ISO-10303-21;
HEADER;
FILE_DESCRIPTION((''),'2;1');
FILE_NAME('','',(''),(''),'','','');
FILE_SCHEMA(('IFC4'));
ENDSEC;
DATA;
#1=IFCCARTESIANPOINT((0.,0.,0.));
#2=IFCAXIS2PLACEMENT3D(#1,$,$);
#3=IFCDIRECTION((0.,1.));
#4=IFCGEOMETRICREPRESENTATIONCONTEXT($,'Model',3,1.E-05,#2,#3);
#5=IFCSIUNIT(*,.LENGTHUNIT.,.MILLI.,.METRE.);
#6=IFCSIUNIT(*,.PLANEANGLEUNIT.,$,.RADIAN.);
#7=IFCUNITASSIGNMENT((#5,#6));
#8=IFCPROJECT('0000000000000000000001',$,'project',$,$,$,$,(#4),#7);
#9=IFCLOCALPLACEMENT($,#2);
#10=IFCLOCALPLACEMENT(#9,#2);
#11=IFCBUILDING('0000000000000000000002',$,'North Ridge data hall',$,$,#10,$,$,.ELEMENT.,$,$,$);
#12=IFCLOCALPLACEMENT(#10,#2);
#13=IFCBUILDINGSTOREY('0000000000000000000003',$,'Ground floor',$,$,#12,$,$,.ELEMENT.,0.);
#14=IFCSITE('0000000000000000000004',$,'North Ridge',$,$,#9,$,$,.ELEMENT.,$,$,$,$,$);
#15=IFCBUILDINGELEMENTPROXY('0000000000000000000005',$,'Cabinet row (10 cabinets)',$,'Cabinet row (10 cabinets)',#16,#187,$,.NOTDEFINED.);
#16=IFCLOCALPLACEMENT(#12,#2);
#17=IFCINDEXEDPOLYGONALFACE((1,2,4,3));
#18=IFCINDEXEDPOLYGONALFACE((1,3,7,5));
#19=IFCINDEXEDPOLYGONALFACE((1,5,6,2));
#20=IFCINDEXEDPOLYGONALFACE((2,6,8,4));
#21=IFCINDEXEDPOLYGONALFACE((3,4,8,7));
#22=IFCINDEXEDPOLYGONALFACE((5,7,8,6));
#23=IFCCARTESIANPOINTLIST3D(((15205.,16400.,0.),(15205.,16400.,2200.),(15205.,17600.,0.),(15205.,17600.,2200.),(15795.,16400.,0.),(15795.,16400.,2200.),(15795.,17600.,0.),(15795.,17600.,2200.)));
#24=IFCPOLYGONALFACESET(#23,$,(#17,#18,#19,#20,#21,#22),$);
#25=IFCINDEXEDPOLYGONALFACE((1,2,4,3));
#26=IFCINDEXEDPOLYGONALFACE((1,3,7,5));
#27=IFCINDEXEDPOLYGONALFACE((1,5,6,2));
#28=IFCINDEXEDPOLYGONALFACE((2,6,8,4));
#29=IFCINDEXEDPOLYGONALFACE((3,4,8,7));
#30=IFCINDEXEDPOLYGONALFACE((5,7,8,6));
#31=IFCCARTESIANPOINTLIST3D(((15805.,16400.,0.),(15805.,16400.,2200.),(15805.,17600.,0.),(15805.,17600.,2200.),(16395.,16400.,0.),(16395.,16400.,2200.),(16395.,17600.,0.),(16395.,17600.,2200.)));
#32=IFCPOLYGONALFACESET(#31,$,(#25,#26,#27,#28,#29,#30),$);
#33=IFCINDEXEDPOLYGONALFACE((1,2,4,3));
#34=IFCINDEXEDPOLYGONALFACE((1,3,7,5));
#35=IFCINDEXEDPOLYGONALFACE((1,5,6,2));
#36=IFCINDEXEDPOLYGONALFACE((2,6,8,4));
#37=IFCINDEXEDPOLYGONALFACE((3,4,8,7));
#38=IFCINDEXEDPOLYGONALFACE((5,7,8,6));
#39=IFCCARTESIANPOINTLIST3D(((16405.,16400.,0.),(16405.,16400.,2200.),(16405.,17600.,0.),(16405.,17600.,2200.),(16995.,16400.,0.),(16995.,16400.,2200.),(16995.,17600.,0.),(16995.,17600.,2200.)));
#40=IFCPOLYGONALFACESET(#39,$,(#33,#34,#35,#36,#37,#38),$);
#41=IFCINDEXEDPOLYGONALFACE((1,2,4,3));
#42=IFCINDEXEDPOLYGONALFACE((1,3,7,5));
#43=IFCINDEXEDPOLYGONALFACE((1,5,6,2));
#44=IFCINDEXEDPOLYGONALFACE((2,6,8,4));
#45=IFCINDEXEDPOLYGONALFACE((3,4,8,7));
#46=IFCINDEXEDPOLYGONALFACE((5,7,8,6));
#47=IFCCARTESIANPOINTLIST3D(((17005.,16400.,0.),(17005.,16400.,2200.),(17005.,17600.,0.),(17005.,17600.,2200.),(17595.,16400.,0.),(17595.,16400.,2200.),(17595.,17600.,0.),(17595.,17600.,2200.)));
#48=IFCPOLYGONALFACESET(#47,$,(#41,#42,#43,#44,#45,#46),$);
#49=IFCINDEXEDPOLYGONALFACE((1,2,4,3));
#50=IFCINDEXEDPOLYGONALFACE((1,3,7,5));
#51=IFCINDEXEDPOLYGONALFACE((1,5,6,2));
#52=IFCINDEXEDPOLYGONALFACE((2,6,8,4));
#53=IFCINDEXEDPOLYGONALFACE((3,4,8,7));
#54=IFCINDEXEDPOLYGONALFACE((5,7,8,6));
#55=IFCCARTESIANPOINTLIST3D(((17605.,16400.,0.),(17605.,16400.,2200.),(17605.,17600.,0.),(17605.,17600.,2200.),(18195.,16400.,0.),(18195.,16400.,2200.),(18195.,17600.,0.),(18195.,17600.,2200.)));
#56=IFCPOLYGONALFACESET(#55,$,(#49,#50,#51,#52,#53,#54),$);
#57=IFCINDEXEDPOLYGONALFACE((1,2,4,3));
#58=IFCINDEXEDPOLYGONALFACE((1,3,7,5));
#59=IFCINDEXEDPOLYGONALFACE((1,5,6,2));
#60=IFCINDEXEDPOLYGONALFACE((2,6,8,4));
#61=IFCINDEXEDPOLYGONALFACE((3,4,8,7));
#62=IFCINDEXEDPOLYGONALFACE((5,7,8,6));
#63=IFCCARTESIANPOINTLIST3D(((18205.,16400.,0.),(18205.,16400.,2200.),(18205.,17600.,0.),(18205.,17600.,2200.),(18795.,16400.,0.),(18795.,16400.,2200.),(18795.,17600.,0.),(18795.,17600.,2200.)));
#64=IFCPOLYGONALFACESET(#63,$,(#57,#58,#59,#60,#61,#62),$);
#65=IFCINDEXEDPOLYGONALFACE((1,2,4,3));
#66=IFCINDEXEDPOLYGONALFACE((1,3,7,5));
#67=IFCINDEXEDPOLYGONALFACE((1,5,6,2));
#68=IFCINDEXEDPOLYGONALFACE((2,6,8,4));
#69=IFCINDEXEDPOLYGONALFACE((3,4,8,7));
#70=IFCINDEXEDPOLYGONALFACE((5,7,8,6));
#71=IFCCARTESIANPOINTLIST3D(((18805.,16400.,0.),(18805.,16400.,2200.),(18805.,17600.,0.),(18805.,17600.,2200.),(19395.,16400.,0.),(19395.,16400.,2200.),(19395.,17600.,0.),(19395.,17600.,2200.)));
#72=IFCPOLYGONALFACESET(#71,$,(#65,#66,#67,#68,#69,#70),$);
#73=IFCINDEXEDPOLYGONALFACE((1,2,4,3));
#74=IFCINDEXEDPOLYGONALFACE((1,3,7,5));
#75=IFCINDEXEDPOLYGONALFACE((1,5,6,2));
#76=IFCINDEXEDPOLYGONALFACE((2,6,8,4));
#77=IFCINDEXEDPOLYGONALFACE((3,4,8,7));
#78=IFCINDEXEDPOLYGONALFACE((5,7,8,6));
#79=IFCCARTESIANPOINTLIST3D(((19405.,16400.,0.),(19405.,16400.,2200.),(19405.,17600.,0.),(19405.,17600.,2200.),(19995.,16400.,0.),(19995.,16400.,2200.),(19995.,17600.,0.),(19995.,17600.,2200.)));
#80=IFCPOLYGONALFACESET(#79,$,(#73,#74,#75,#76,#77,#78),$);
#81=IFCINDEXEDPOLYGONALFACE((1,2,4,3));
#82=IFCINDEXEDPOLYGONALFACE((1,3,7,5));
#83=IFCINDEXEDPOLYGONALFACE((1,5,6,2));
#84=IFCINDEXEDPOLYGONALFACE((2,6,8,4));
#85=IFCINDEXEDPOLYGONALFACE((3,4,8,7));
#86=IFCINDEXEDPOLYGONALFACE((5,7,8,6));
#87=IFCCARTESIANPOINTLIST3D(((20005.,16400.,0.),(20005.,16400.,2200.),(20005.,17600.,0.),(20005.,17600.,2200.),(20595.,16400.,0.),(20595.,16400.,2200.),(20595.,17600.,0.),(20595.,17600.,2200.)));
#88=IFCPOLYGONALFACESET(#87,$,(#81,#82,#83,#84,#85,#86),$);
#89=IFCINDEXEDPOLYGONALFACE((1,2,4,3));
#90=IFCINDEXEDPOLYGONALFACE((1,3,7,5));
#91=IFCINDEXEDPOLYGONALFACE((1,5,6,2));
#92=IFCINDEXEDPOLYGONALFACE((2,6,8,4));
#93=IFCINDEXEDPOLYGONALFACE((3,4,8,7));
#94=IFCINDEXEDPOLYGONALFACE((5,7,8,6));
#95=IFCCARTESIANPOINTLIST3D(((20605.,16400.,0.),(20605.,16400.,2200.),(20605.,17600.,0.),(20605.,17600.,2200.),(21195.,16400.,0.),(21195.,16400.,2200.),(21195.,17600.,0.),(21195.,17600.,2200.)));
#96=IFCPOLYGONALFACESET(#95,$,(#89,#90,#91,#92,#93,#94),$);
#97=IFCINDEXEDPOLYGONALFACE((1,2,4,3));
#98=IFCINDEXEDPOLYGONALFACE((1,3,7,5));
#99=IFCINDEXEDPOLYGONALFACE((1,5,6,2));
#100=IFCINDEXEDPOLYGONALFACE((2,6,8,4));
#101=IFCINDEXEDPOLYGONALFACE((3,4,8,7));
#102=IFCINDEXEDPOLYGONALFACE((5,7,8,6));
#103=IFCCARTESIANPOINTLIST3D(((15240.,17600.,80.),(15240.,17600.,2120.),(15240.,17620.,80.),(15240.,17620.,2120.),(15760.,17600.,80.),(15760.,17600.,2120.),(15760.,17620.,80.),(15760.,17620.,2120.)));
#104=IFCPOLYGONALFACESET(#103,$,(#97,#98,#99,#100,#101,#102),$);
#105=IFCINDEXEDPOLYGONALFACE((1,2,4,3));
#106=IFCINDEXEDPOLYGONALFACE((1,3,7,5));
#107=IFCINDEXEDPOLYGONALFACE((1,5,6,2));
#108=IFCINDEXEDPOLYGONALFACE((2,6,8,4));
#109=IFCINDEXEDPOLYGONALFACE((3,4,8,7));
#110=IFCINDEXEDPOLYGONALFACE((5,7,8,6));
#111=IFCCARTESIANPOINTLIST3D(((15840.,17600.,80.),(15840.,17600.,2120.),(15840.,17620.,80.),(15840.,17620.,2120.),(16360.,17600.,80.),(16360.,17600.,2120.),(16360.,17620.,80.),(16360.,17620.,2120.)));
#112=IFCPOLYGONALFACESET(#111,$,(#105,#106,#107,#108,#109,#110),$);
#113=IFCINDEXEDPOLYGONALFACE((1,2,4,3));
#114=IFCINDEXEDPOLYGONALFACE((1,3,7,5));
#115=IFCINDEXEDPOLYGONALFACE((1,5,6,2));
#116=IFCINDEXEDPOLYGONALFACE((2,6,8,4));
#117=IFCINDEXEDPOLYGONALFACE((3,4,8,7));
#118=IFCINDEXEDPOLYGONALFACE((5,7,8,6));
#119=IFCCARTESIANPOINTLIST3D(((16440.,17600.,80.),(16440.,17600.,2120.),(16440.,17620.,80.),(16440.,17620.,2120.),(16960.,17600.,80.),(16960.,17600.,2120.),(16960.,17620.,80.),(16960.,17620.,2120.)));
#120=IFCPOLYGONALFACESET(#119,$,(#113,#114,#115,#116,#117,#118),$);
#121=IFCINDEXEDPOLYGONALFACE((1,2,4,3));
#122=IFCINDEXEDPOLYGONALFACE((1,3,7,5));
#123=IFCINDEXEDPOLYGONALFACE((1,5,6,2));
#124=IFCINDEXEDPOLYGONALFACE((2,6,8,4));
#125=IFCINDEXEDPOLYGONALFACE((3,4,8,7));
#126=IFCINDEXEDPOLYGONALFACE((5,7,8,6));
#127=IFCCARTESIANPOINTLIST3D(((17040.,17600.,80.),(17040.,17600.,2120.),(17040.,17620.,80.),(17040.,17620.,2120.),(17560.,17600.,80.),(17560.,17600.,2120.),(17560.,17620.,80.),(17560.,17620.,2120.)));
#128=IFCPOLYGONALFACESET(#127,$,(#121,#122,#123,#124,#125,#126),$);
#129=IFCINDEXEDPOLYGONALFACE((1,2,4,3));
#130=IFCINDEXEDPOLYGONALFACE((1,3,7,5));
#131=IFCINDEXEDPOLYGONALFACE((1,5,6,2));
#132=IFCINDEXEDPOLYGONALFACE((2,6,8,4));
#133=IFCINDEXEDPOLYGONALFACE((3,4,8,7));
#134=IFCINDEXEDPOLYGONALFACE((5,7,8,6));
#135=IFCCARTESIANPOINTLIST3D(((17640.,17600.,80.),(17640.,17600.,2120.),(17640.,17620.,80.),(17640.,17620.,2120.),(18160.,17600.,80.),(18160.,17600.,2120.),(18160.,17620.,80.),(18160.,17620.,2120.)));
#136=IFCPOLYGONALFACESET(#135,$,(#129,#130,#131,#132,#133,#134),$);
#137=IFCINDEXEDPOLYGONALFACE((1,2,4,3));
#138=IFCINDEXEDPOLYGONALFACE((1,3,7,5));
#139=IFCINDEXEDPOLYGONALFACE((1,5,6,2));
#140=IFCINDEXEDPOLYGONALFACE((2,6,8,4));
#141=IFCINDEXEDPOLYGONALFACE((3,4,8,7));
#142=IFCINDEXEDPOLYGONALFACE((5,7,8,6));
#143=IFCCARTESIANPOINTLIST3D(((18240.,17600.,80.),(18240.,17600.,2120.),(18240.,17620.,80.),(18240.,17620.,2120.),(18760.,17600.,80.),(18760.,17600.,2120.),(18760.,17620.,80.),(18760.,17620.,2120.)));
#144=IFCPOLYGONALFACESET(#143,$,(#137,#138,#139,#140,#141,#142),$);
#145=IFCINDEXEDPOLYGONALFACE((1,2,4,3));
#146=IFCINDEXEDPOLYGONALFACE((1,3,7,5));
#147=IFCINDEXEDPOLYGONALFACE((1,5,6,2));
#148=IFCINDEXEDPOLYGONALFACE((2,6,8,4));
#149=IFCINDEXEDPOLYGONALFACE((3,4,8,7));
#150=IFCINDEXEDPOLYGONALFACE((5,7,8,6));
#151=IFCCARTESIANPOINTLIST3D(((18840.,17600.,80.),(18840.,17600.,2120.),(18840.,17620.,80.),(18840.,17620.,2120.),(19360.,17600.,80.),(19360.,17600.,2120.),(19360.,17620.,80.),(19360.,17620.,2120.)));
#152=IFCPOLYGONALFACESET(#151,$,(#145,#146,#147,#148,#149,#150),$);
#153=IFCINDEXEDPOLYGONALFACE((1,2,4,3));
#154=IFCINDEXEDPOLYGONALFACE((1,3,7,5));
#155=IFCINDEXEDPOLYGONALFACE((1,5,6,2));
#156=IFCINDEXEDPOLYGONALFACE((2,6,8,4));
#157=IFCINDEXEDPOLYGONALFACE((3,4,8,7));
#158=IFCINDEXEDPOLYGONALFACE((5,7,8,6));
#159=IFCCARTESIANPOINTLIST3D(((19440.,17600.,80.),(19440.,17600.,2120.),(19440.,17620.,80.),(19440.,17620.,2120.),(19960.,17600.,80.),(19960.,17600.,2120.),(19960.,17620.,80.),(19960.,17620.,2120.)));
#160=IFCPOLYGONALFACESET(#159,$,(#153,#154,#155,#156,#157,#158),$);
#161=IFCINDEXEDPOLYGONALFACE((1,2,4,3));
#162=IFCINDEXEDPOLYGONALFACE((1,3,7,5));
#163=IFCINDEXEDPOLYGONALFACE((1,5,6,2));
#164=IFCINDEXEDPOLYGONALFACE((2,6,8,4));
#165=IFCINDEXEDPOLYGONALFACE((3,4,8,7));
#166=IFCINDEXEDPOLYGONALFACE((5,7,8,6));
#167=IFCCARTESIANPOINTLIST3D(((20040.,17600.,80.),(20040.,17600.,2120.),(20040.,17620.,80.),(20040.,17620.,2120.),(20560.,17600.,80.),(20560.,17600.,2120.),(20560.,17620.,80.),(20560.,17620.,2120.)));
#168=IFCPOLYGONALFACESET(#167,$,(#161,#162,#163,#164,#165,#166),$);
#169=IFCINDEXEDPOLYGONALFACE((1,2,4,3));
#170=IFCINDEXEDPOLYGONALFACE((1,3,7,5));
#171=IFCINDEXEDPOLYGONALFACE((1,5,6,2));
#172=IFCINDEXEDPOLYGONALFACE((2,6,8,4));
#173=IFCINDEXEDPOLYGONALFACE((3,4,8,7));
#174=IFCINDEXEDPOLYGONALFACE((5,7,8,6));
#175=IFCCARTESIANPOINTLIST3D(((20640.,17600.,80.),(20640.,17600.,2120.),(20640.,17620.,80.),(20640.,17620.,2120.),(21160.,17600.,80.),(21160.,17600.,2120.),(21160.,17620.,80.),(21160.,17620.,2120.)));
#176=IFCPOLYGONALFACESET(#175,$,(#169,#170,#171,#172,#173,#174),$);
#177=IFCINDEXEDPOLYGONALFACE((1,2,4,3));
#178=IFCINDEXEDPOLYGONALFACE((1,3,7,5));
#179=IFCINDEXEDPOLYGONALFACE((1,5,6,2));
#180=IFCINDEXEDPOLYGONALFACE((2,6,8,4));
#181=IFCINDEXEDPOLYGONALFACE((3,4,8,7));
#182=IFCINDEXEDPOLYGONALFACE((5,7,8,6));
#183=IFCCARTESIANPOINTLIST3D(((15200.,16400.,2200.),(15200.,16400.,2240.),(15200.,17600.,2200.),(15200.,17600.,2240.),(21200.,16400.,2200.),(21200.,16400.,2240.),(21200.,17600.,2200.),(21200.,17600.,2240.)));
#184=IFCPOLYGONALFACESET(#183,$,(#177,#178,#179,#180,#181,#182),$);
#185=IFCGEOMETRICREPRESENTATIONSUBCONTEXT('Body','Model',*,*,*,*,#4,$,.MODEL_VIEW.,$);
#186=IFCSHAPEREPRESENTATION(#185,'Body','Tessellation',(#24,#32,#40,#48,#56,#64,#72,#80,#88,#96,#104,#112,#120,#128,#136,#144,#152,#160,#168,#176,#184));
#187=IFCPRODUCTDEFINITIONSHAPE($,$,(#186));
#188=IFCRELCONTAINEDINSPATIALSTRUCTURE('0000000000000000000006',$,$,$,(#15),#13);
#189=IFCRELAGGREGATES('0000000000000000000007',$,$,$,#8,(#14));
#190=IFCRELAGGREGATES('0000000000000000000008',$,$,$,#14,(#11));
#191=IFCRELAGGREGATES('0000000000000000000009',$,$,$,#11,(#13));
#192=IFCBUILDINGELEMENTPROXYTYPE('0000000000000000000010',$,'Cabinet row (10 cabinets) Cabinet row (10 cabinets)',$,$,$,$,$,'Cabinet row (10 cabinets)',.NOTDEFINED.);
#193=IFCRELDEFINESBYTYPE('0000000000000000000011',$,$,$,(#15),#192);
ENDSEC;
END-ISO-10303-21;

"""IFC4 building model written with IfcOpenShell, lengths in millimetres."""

from ifc_helpers import new_model, si_unit, direction, frame, origin, place, context, subcontext, project, spatial, polyline, outline, extrude, source, transform, mapped, type_object, type_shapes, element, save


model = new_model("IFC4")

# Units and contexts
model_context = context("Model", 3, precision=1e-05, world=origin(), true_north=direction((0.0, 1.0)))
body_context = subcontext(model_context, "Body", "Model", "MODEL_VIEW")
ifc_project = project(units=[si_unit("LENGTHUNIT", "METRE", prefix="MILLI"), si_unit("PLANEANGLEUNIT", "RADIAN")], contexts=[model_context])

# Site, building, storey
site_placement = place(None, origin())
site = spatial("IfcSite", under=ifc_project, at=site_placement, Name="North Ridge", CompositionType="ELEMENT")
building_placement = place(site_placement, origin())
building = spatial("IfcBuilding", under=site, at=building_placement, Name="North Ridge data hall", CompositionType="ELEMENT")
storey_placement = place(building_placement, origin())
storey = spatial("IfcBuildingStorey", under=building, at=storey_placement, Name="Ground floor", CompositionType="ELEMENT", Elevation=0.0)

# Building element proxy
building_element_proxy_type_1 = type_object("IfcBuildingElementProxyType", Name="Cabinet row (10 cabinets) Cabinet row (10 cabinets)", ElementType="Cabinet row (10 cabinets)", PredefinedType="NOTDEFINED")
shared_shape_1 = source(origin(), body_context, "Body", "SweptSolid", [
    extrude(outline(polyline([(5.0, 0.0), (595.0, 0.0), (595.0, 1200.0), (5.0, 1200.0), (5.0, 0.0)])), origin(), (0.0, 0.0, 1.0), 2200.0),
    extrude(outline(polyline([(605.0, 0.0), (1195.0, 0.0), (1195.0, 1200.0), (605.0, 1200.0), (605.0, 0.0)])), origin(), (0.0, 0.0, 1.0), 2200.0),
    extrude(outline(polyline([(1205.0, 0.0), (1795.0, 0.0), (1795.0, 1200.0), (1205.0, 1200.0), (1205.0, 0.0)])), origin(), (0.0, 0.0, 1.0), 2200.0),
    extrude(outline(polyline([(1805.0, 0.0), (2395.0, 0.0), (2395.0, 1200.0), (1805.0, 1200.0), (1805.0, 0.0)])), origin(), (0.0, 0.0, 1.0), 2200.0),
    extrude(outline(polyline([(2405.0, 0.0), (2995.0, 0.0), (2995.0, 1200.0), (2405.0, 1200.0), (2405.0, 0.0)])), origin(), (0.0, 0.0, 1.0), 2200.0),
    extrude(outline(polyline([(3005.0, 0.0), (3595.0, 0.0), (3595.0, 1200.0), (3005.0, 1200.0), (3005.0, 0.0)])), origin(), (0.0, 0.0, 1.0), 2200.0),
    extrude(outline(polyline([(3605.0, 0.0), (4195.0, 0.0), (4195.0, 1200.0), (3605.0, 1200.0), (3605.0, 0.0)])), origin(), (0.0, 0.0, 1.0), 2200.0),
    extrude(outline(polyline([(4205.0, 0.0), (4795.0, 0.0), (4795.0, 1200.0), (4205.0, 1200.0), (4205.0, 0.0)])), origin(), (0.0, 0.0, 1.0), 2200.0),
    extrude(outline(polyline([(4805.0, 0.0), (5395.0, 0.0), (5395.0, 1200.0), (4805.0, 1200.0), (4805.0, 0.0)])), origin(), (0.0, 0.0, 1.0), 2200.0),
    extrude(outline(polyline([(5405.0, 0.0), (5995.0, 0.0), (5995.0, 1200.0), (5405.0, 1200.0), (5405.0, 0.0)])), origin(), (0.0, 0.0, 1.0), 2200.0),
    extrude(outline(polyline([(40.0, 1200.0), (560.0, 1200.0), (560.0, 1220.0), (40.0, 1220.0), (40.0, 1200.0)])), frame((0.0, 0.0, 80.0)), (0.0, 0.0, 1.0), 2040.0),
    extrude(outline(polyline([(640.0, 1200.0), (1160.0, 1200.0), (1160.0, 1220.0), (640.0, 1220.0), (640.0, 1200.0)])), frame((0.0, 0.0, 80.0)), (0.0, 0.0, 1.0), 2040.0),
    extrude(outline(polyline([(1240.0, 1200.0), (1760.0, 1200.0), (1760.0, 1220.0), (1240.0, 1220.0), (1240.0, 1200.0)])), frame((0.0, 0.0, 80.0)), (0.0, 0.0, 1.0), 2040.0),
    extrude(outline(polyline([(1840.0, 1200.0), (2360.0, 1200.0), (2360.0, 1220.0), (1840.0, 1220.0), (1840.0, 1200.0)])), frame((0.0, 0.0, 80.0)), (0.0, 0.0, 1.0), 2040.0),
    extrude(outline(polyline([(2440.0, 1200.0), (2960.0, 1200.0), (2960.0, 1220.0), (2440.0, 1220.0), (2440.0, 1200.0)])), frame((0.0, 0.0, 80.0)), (0.0, 0.0, 1.0), 2040.0),
    extrude(outline(polyline([(3040.0, 1200.0), (3560.0, 1200.0), (3560.0, 1220.0), (3040.0, 1220.0), (3040.0, 1200.0)])), frame((0.0, 0.0, 80.0)), (0.0, 0.0, 1.0), 2040.0),
    extrude(outline(polyline([(3640.0, 1200.0), (4160.0, 1200.0), (4160.0, 1220.0), (3640.0, 1220.0), (3640.0, 1200.0)])), frame((0.0, 0.0, 80.0)), (0.0, 0.0, 1.0), 2040.0),
    extrude(outline(polyline([(4240.0, 1200.0), (4760.0, 1200.0), (4760.0, 1220.0), (4240.0, 1220.0), (4240.0, 1200.0)])), frame((0.0, 0.0, 80.0)), (0.0, 0.0, 1.0), 2040.0),
    extrude(outline(polyline([(4840.0, 1200.0), (5360.0, 1200.0), (5360.0, 1220.0), (4840.0, 1220.0), (4840.0, 1200.0)])), frame((0.0, 0.0, 80.0)), (0.0, 0.0, 1.0), 2040.0),
    extrude(outline(polyline([(5440.0, 1200.0), (5960.0, 1200.0), (5960.0, 1220.0), (5440.0, 1220.0), (5440.0, 1200.0)])), frame((0.0, 0.0, 80.0)), (0.0, 0.0, 1.0), 2040.0),
    extrude(outline(polyline([(0.0, 0.0), (6000.0, 0.0), (6000.0, 1200.0), (0.0, 1200.0), (0.0, 0.0)])), frame((0.0, 0.0, 2200.0)), (0.0, 0.0, 1.0), 40.0),
])
type_shapes(building_element_proxy_type_1, [shared_shape_1])
for number, where, z_axis, x_axis, name in (
    (1, (15200.0, 16400.0, 0.0), (0.0, 0.0, 1.0), (1.0, 0.0, 0.0), "Cabinet row (10 cabinets)"),
):
    element("IfcBuildingElementProxy", number, at=place(storey_placement, frame(where, z_axis=z_axis, x_axis=x_axis)), inside=storey, type_object=building_element_proxy_type_1, Name=name, ObjectType="Cabinet row (10 cabinets)", PredefinedType="NOTDEFINED", context=body_context, shape_type="MappedRepresentation", body=[
        mapped(shared_shape_1, transform((0.0, 0.0, 0.0))),
    ])

save(model, "model.ifc")
